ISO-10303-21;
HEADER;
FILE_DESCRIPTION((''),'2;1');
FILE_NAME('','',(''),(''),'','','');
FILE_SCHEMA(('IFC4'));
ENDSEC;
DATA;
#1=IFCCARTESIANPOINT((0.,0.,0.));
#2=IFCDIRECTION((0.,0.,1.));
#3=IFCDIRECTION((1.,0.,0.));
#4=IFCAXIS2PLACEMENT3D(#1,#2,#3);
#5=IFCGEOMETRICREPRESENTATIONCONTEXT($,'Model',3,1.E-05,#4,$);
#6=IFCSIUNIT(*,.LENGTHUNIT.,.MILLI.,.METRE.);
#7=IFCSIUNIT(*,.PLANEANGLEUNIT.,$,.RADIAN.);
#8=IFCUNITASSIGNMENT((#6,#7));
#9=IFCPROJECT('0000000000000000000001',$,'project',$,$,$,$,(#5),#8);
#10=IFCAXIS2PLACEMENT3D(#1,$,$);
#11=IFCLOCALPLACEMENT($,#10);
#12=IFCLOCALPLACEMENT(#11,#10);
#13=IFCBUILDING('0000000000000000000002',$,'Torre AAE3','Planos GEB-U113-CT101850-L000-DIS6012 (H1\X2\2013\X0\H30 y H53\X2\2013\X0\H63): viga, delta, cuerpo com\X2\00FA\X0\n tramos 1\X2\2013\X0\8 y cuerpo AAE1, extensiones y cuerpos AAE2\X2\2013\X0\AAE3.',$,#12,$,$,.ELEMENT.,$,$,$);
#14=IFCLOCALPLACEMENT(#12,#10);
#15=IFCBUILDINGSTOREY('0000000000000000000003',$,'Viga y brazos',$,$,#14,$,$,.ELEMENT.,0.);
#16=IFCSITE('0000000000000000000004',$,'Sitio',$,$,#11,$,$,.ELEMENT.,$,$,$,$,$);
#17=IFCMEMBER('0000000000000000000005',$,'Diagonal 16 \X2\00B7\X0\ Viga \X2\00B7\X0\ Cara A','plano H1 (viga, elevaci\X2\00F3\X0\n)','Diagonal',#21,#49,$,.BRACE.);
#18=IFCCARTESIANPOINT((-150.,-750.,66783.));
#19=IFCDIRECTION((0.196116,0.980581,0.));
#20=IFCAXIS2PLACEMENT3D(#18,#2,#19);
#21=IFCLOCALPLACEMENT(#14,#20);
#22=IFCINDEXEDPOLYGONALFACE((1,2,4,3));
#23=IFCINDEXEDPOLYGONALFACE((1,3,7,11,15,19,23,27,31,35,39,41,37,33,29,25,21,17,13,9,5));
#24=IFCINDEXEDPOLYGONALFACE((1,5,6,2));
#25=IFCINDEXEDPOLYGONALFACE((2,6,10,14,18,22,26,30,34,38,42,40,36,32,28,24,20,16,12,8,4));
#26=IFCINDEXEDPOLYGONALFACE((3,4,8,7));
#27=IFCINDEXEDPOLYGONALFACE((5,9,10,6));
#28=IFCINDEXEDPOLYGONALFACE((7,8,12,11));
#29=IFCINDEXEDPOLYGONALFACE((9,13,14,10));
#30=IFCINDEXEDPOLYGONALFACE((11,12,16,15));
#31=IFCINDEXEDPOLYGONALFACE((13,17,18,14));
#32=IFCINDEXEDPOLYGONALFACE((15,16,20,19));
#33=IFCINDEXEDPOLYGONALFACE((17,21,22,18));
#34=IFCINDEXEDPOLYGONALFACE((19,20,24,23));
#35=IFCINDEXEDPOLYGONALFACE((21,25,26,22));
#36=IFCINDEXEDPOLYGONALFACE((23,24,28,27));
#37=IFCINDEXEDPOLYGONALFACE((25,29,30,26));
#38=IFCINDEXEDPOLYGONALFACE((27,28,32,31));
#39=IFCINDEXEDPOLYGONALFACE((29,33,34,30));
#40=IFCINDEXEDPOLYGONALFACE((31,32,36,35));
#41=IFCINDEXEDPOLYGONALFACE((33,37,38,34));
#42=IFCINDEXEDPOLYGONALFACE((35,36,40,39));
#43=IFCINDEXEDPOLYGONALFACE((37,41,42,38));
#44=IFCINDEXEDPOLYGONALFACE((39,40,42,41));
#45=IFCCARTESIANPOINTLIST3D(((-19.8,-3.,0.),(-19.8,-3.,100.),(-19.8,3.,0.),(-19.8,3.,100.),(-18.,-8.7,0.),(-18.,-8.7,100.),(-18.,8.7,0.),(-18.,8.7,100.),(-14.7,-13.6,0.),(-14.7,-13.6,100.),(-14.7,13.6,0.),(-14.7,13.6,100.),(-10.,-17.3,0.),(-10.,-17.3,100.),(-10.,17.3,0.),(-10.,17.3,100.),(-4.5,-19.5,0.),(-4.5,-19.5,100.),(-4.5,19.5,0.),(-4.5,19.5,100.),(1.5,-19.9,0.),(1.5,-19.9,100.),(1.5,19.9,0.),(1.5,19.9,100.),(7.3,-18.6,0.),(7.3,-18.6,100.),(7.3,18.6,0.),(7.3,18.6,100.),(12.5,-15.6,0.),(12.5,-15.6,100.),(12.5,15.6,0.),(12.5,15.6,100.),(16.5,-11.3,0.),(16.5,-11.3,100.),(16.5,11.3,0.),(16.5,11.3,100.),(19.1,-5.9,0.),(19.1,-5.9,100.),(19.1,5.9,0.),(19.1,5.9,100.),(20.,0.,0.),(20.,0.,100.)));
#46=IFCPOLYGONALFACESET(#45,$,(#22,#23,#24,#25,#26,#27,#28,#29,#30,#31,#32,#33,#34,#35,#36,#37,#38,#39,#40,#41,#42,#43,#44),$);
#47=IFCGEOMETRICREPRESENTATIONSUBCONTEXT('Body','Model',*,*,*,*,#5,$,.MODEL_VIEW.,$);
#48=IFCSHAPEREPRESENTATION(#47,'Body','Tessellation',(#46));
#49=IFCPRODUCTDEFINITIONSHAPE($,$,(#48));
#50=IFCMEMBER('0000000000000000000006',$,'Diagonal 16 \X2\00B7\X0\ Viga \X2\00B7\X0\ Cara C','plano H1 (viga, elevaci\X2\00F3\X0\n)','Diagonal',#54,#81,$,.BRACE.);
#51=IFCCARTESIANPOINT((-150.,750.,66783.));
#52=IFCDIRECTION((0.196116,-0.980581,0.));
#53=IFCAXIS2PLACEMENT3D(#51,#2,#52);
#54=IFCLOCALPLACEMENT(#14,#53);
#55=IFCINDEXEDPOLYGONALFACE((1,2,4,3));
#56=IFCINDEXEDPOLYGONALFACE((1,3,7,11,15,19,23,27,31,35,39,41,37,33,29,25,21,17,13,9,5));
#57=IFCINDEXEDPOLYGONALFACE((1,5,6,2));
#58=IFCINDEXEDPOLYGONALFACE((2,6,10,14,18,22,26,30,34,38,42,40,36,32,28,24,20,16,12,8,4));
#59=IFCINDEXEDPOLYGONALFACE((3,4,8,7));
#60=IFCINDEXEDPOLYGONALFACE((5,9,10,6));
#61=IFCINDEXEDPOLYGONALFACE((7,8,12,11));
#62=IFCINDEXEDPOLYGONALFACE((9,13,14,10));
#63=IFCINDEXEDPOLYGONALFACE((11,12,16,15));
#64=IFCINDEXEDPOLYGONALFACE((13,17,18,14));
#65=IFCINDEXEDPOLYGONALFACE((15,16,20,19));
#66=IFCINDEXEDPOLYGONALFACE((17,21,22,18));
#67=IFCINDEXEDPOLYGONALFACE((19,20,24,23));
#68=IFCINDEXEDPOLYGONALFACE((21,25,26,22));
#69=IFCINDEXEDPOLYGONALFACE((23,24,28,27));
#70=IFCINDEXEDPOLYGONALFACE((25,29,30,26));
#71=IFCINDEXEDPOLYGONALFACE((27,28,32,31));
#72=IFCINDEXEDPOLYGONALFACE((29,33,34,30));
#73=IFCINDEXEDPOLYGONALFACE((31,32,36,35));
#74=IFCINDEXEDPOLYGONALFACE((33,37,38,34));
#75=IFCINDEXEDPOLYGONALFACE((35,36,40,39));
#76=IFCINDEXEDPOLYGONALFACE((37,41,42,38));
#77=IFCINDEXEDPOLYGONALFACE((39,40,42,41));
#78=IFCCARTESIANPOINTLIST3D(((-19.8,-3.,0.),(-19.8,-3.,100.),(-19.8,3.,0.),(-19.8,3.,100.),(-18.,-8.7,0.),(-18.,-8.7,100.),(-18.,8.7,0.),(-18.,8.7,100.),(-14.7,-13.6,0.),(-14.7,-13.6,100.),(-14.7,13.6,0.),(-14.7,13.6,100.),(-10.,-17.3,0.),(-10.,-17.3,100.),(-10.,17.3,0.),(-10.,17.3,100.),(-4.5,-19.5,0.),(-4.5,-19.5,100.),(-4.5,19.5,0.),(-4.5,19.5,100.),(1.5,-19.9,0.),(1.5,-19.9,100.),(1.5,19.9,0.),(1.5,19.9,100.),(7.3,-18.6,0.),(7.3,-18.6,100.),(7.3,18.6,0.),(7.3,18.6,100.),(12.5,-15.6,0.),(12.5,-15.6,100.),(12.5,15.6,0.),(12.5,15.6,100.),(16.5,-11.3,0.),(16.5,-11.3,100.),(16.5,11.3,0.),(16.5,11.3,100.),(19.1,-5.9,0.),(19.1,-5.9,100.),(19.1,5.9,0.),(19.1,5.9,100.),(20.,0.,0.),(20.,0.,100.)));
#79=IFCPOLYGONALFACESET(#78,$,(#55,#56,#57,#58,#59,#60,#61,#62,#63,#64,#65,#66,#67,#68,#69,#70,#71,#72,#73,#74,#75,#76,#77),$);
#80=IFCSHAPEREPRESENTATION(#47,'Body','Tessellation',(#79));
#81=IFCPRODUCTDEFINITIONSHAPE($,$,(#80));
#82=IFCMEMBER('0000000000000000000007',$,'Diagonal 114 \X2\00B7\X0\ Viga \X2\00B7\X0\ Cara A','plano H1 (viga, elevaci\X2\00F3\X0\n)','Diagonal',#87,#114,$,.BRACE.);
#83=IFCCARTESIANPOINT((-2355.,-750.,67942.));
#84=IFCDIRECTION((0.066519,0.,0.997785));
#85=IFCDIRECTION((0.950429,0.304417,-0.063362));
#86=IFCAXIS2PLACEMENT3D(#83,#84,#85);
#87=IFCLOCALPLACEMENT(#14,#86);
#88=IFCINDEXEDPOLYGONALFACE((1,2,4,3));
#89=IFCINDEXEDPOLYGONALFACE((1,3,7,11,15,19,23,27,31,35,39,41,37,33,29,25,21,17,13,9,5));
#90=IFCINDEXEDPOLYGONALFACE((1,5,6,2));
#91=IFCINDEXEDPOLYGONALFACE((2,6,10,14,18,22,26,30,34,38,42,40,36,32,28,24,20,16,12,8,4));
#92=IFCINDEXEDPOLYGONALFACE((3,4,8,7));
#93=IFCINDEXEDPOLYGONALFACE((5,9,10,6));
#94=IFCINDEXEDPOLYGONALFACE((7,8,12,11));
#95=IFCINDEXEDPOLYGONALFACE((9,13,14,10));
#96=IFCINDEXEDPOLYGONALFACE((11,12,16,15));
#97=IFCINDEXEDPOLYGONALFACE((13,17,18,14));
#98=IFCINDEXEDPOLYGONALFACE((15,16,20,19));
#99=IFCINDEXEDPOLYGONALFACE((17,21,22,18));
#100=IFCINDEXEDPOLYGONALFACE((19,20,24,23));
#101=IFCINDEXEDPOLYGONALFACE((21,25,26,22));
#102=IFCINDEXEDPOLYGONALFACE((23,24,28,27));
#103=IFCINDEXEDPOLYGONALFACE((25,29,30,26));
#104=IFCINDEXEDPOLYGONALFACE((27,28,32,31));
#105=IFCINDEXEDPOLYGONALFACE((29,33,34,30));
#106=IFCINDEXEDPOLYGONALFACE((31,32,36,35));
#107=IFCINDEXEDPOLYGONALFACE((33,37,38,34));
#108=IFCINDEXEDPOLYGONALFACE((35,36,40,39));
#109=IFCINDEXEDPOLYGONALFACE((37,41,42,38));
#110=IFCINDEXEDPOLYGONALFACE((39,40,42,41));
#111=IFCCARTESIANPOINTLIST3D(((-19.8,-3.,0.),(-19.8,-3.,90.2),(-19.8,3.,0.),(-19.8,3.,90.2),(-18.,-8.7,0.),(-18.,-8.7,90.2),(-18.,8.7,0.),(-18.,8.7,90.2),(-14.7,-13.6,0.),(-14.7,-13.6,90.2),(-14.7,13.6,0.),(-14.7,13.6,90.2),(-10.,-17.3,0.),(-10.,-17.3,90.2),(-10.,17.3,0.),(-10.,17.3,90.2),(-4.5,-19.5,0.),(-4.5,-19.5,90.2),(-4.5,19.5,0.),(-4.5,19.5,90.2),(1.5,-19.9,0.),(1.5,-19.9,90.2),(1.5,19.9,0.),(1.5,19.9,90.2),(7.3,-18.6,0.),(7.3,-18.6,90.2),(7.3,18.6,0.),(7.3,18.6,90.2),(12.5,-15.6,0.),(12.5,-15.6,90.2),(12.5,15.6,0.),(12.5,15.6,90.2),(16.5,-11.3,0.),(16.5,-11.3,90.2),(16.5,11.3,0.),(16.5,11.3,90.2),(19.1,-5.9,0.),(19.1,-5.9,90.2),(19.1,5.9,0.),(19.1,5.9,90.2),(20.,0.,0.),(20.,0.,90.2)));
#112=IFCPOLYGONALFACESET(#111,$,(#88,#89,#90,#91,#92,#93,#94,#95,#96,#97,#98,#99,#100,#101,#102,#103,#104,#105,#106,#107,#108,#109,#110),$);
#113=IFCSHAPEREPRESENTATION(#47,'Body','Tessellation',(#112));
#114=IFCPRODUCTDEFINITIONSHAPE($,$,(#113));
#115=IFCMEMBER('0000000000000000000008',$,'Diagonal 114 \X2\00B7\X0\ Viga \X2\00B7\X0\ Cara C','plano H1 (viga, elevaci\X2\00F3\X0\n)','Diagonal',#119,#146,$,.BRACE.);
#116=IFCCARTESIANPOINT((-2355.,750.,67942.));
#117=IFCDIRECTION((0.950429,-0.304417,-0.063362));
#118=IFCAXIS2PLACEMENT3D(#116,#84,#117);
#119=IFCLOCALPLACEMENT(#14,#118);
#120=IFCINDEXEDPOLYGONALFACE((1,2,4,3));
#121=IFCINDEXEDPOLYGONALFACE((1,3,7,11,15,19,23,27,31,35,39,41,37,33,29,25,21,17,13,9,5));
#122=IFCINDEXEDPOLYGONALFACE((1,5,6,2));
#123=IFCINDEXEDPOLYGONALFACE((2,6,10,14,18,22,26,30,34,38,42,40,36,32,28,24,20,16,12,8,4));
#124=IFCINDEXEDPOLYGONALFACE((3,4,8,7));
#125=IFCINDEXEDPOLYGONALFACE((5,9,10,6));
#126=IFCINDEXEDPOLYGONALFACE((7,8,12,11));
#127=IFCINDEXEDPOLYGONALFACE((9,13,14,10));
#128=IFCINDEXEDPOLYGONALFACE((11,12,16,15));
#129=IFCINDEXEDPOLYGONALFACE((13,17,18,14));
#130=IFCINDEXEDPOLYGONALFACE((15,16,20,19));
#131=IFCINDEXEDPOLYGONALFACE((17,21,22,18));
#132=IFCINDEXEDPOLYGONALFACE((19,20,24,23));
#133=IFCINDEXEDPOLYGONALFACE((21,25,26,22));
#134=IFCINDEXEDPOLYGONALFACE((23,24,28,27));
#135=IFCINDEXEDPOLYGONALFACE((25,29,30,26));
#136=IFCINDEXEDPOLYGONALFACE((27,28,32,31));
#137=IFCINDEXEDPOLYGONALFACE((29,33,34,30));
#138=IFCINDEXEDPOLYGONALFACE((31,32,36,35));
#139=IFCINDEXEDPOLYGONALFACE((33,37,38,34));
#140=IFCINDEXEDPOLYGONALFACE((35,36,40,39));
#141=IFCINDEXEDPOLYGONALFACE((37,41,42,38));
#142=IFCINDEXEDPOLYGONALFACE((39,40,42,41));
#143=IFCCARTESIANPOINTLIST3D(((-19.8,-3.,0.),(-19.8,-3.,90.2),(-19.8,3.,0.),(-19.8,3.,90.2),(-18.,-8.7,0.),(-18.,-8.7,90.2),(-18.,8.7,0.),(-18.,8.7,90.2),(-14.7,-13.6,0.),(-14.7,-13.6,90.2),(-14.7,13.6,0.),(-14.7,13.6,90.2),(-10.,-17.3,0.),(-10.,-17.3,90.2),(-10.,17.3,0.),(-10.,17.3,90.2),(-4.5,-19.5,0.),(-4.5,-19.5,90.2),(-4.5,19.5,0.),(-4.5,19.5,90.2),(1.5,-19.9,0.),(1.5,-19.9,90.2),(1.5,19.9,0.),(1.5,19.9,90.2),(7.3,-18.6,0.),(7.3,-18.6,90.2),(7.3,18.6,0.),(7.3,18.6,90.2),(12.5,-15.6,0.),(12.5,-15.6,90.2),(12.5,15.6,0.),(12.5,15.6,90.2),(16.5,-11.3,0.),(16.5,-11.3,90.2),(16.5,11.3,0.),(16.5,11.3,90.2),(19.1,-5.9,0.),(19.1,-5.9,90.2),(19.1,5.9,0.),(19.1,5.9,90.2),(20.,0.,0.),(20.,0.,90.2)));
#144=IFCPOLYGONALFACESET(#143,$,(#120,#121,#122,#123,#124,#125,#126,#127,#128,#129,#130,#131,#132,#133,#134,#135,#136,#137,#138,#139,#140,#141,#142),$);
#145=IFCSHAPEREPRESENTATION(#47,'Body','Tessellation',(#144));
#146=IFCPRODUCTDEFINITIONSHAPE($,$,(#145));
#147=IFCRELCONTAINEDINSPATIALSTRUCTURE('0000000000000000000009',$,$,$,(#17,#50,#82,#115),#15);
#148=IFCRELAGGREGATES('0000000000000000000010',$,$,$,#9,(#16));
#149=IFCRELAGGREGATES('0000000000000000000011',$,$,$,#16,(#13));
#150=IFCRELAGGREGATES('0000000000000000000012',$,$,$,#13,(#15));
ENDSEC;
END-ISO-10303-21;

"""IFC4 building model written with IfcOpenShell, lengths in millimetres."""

from ifc_helpers import new_model, si_unit, frame, origin, origin_with_axes, place, context, subcontext, project, spatial, circle, extrude, element, save


model = new_model("IFC4")

# Units and contexts
model_context = context("Model", 3, precision=1e-05, world=origin_with_axes())
body_context = subcontext(model_context, "Body", "Model", "MODEL_VIEW")
ifc_project = project(units=[si_unit("LENGTHUNIT", "METRE", prefix="MILLI"), si_unit("PLANEANGLEUNIT", "RADIAN")], contexts=[model_context])

# Site, building, storey
site_placement = place(None, origin())
site = spatial("IfcSite", under=ifc_project, at=site_placement, Name="Sitio", CompositionType="ELEMENT")
building_placement = place(site_placement, origin())
building = spatial("IfcBuilding", under=site, at=building_placement, Name="Torre AAE3", Description="Planos GEB-U113-CT101850-L000-DIS6012 (H1–H30 y H53–H63): viga, delta, cuerpo común tramos 1–8 y cuerpo AAE1, extensiones y cuerpos AAE2–AAE3.", CompositionType="ELEMENT")
storey_placement = place(building_placement, origin())
storey = spatial("IfcBuildingStorey", under=building, at=storey_placement, Name="Viga y brazos", CompositionType="ELEMENT", Elevation=0.0)

# Members
for number, where, z_axis, x_axis, name in (
    (1, (-150.0, -750.0, 66783.0), (0.0, 0.0, 1.0), (0.196116, 0.980581, 0.0), "Diagonal 16 · Viga · Cara A"),
    (2, (-150.0, 750.0, 66783.0), (0.0, 0.0, 1.0), (0.196116, -0.980581, 0.0), "Diagonal 16 · Viga · Cara C"),
):
    element("IfcMember", number, at=place(storey_placement, frame(where, z_axis=z_axis, x_axis=x_axis)), inside=storey, Name=name, Description="plano H1 (viga, elevación)", ObjectType="Diagonal", PredefinedType="BRACE", context=body_context, shape_type="SweptSolid", body=[
        extrude(circle(Radius=20.0), None, (0.0, 0.0, 1.0), 100.0),
    ])
for number, where, z_axis, x_axis, name in (
    (3, (-2355.0, -750.0, 67942.0), (0.066519, 0.0, 0.997785), (0.950429, 0.304417, -0.063362), "Diagonal 114 · Viga · Cara A"),
    (4, (-2355.0, 750.0, 67942.0), (0.066519, 0.0, 0.997785), (0.950429, -0.304417, -0.063362), "Diagonal 114 · Viga · Cara C"),
):
    element("IfcMember", number, at=place(storey_placement, frame(where, z_axis=z_axis, x_axis=x_axis)), inside=storey, Name=name, Description="plano H1 (viga, elevación)", ObjectType="Diagonal", PredefinedType="BRACE", context=body_context, shape_type="SweptSolid", body=[
        extrude(circle(Radius=20.0), None, (0.0, 0.0, 1.0), 90.2),
    ])

save(model, "model.ifc")
